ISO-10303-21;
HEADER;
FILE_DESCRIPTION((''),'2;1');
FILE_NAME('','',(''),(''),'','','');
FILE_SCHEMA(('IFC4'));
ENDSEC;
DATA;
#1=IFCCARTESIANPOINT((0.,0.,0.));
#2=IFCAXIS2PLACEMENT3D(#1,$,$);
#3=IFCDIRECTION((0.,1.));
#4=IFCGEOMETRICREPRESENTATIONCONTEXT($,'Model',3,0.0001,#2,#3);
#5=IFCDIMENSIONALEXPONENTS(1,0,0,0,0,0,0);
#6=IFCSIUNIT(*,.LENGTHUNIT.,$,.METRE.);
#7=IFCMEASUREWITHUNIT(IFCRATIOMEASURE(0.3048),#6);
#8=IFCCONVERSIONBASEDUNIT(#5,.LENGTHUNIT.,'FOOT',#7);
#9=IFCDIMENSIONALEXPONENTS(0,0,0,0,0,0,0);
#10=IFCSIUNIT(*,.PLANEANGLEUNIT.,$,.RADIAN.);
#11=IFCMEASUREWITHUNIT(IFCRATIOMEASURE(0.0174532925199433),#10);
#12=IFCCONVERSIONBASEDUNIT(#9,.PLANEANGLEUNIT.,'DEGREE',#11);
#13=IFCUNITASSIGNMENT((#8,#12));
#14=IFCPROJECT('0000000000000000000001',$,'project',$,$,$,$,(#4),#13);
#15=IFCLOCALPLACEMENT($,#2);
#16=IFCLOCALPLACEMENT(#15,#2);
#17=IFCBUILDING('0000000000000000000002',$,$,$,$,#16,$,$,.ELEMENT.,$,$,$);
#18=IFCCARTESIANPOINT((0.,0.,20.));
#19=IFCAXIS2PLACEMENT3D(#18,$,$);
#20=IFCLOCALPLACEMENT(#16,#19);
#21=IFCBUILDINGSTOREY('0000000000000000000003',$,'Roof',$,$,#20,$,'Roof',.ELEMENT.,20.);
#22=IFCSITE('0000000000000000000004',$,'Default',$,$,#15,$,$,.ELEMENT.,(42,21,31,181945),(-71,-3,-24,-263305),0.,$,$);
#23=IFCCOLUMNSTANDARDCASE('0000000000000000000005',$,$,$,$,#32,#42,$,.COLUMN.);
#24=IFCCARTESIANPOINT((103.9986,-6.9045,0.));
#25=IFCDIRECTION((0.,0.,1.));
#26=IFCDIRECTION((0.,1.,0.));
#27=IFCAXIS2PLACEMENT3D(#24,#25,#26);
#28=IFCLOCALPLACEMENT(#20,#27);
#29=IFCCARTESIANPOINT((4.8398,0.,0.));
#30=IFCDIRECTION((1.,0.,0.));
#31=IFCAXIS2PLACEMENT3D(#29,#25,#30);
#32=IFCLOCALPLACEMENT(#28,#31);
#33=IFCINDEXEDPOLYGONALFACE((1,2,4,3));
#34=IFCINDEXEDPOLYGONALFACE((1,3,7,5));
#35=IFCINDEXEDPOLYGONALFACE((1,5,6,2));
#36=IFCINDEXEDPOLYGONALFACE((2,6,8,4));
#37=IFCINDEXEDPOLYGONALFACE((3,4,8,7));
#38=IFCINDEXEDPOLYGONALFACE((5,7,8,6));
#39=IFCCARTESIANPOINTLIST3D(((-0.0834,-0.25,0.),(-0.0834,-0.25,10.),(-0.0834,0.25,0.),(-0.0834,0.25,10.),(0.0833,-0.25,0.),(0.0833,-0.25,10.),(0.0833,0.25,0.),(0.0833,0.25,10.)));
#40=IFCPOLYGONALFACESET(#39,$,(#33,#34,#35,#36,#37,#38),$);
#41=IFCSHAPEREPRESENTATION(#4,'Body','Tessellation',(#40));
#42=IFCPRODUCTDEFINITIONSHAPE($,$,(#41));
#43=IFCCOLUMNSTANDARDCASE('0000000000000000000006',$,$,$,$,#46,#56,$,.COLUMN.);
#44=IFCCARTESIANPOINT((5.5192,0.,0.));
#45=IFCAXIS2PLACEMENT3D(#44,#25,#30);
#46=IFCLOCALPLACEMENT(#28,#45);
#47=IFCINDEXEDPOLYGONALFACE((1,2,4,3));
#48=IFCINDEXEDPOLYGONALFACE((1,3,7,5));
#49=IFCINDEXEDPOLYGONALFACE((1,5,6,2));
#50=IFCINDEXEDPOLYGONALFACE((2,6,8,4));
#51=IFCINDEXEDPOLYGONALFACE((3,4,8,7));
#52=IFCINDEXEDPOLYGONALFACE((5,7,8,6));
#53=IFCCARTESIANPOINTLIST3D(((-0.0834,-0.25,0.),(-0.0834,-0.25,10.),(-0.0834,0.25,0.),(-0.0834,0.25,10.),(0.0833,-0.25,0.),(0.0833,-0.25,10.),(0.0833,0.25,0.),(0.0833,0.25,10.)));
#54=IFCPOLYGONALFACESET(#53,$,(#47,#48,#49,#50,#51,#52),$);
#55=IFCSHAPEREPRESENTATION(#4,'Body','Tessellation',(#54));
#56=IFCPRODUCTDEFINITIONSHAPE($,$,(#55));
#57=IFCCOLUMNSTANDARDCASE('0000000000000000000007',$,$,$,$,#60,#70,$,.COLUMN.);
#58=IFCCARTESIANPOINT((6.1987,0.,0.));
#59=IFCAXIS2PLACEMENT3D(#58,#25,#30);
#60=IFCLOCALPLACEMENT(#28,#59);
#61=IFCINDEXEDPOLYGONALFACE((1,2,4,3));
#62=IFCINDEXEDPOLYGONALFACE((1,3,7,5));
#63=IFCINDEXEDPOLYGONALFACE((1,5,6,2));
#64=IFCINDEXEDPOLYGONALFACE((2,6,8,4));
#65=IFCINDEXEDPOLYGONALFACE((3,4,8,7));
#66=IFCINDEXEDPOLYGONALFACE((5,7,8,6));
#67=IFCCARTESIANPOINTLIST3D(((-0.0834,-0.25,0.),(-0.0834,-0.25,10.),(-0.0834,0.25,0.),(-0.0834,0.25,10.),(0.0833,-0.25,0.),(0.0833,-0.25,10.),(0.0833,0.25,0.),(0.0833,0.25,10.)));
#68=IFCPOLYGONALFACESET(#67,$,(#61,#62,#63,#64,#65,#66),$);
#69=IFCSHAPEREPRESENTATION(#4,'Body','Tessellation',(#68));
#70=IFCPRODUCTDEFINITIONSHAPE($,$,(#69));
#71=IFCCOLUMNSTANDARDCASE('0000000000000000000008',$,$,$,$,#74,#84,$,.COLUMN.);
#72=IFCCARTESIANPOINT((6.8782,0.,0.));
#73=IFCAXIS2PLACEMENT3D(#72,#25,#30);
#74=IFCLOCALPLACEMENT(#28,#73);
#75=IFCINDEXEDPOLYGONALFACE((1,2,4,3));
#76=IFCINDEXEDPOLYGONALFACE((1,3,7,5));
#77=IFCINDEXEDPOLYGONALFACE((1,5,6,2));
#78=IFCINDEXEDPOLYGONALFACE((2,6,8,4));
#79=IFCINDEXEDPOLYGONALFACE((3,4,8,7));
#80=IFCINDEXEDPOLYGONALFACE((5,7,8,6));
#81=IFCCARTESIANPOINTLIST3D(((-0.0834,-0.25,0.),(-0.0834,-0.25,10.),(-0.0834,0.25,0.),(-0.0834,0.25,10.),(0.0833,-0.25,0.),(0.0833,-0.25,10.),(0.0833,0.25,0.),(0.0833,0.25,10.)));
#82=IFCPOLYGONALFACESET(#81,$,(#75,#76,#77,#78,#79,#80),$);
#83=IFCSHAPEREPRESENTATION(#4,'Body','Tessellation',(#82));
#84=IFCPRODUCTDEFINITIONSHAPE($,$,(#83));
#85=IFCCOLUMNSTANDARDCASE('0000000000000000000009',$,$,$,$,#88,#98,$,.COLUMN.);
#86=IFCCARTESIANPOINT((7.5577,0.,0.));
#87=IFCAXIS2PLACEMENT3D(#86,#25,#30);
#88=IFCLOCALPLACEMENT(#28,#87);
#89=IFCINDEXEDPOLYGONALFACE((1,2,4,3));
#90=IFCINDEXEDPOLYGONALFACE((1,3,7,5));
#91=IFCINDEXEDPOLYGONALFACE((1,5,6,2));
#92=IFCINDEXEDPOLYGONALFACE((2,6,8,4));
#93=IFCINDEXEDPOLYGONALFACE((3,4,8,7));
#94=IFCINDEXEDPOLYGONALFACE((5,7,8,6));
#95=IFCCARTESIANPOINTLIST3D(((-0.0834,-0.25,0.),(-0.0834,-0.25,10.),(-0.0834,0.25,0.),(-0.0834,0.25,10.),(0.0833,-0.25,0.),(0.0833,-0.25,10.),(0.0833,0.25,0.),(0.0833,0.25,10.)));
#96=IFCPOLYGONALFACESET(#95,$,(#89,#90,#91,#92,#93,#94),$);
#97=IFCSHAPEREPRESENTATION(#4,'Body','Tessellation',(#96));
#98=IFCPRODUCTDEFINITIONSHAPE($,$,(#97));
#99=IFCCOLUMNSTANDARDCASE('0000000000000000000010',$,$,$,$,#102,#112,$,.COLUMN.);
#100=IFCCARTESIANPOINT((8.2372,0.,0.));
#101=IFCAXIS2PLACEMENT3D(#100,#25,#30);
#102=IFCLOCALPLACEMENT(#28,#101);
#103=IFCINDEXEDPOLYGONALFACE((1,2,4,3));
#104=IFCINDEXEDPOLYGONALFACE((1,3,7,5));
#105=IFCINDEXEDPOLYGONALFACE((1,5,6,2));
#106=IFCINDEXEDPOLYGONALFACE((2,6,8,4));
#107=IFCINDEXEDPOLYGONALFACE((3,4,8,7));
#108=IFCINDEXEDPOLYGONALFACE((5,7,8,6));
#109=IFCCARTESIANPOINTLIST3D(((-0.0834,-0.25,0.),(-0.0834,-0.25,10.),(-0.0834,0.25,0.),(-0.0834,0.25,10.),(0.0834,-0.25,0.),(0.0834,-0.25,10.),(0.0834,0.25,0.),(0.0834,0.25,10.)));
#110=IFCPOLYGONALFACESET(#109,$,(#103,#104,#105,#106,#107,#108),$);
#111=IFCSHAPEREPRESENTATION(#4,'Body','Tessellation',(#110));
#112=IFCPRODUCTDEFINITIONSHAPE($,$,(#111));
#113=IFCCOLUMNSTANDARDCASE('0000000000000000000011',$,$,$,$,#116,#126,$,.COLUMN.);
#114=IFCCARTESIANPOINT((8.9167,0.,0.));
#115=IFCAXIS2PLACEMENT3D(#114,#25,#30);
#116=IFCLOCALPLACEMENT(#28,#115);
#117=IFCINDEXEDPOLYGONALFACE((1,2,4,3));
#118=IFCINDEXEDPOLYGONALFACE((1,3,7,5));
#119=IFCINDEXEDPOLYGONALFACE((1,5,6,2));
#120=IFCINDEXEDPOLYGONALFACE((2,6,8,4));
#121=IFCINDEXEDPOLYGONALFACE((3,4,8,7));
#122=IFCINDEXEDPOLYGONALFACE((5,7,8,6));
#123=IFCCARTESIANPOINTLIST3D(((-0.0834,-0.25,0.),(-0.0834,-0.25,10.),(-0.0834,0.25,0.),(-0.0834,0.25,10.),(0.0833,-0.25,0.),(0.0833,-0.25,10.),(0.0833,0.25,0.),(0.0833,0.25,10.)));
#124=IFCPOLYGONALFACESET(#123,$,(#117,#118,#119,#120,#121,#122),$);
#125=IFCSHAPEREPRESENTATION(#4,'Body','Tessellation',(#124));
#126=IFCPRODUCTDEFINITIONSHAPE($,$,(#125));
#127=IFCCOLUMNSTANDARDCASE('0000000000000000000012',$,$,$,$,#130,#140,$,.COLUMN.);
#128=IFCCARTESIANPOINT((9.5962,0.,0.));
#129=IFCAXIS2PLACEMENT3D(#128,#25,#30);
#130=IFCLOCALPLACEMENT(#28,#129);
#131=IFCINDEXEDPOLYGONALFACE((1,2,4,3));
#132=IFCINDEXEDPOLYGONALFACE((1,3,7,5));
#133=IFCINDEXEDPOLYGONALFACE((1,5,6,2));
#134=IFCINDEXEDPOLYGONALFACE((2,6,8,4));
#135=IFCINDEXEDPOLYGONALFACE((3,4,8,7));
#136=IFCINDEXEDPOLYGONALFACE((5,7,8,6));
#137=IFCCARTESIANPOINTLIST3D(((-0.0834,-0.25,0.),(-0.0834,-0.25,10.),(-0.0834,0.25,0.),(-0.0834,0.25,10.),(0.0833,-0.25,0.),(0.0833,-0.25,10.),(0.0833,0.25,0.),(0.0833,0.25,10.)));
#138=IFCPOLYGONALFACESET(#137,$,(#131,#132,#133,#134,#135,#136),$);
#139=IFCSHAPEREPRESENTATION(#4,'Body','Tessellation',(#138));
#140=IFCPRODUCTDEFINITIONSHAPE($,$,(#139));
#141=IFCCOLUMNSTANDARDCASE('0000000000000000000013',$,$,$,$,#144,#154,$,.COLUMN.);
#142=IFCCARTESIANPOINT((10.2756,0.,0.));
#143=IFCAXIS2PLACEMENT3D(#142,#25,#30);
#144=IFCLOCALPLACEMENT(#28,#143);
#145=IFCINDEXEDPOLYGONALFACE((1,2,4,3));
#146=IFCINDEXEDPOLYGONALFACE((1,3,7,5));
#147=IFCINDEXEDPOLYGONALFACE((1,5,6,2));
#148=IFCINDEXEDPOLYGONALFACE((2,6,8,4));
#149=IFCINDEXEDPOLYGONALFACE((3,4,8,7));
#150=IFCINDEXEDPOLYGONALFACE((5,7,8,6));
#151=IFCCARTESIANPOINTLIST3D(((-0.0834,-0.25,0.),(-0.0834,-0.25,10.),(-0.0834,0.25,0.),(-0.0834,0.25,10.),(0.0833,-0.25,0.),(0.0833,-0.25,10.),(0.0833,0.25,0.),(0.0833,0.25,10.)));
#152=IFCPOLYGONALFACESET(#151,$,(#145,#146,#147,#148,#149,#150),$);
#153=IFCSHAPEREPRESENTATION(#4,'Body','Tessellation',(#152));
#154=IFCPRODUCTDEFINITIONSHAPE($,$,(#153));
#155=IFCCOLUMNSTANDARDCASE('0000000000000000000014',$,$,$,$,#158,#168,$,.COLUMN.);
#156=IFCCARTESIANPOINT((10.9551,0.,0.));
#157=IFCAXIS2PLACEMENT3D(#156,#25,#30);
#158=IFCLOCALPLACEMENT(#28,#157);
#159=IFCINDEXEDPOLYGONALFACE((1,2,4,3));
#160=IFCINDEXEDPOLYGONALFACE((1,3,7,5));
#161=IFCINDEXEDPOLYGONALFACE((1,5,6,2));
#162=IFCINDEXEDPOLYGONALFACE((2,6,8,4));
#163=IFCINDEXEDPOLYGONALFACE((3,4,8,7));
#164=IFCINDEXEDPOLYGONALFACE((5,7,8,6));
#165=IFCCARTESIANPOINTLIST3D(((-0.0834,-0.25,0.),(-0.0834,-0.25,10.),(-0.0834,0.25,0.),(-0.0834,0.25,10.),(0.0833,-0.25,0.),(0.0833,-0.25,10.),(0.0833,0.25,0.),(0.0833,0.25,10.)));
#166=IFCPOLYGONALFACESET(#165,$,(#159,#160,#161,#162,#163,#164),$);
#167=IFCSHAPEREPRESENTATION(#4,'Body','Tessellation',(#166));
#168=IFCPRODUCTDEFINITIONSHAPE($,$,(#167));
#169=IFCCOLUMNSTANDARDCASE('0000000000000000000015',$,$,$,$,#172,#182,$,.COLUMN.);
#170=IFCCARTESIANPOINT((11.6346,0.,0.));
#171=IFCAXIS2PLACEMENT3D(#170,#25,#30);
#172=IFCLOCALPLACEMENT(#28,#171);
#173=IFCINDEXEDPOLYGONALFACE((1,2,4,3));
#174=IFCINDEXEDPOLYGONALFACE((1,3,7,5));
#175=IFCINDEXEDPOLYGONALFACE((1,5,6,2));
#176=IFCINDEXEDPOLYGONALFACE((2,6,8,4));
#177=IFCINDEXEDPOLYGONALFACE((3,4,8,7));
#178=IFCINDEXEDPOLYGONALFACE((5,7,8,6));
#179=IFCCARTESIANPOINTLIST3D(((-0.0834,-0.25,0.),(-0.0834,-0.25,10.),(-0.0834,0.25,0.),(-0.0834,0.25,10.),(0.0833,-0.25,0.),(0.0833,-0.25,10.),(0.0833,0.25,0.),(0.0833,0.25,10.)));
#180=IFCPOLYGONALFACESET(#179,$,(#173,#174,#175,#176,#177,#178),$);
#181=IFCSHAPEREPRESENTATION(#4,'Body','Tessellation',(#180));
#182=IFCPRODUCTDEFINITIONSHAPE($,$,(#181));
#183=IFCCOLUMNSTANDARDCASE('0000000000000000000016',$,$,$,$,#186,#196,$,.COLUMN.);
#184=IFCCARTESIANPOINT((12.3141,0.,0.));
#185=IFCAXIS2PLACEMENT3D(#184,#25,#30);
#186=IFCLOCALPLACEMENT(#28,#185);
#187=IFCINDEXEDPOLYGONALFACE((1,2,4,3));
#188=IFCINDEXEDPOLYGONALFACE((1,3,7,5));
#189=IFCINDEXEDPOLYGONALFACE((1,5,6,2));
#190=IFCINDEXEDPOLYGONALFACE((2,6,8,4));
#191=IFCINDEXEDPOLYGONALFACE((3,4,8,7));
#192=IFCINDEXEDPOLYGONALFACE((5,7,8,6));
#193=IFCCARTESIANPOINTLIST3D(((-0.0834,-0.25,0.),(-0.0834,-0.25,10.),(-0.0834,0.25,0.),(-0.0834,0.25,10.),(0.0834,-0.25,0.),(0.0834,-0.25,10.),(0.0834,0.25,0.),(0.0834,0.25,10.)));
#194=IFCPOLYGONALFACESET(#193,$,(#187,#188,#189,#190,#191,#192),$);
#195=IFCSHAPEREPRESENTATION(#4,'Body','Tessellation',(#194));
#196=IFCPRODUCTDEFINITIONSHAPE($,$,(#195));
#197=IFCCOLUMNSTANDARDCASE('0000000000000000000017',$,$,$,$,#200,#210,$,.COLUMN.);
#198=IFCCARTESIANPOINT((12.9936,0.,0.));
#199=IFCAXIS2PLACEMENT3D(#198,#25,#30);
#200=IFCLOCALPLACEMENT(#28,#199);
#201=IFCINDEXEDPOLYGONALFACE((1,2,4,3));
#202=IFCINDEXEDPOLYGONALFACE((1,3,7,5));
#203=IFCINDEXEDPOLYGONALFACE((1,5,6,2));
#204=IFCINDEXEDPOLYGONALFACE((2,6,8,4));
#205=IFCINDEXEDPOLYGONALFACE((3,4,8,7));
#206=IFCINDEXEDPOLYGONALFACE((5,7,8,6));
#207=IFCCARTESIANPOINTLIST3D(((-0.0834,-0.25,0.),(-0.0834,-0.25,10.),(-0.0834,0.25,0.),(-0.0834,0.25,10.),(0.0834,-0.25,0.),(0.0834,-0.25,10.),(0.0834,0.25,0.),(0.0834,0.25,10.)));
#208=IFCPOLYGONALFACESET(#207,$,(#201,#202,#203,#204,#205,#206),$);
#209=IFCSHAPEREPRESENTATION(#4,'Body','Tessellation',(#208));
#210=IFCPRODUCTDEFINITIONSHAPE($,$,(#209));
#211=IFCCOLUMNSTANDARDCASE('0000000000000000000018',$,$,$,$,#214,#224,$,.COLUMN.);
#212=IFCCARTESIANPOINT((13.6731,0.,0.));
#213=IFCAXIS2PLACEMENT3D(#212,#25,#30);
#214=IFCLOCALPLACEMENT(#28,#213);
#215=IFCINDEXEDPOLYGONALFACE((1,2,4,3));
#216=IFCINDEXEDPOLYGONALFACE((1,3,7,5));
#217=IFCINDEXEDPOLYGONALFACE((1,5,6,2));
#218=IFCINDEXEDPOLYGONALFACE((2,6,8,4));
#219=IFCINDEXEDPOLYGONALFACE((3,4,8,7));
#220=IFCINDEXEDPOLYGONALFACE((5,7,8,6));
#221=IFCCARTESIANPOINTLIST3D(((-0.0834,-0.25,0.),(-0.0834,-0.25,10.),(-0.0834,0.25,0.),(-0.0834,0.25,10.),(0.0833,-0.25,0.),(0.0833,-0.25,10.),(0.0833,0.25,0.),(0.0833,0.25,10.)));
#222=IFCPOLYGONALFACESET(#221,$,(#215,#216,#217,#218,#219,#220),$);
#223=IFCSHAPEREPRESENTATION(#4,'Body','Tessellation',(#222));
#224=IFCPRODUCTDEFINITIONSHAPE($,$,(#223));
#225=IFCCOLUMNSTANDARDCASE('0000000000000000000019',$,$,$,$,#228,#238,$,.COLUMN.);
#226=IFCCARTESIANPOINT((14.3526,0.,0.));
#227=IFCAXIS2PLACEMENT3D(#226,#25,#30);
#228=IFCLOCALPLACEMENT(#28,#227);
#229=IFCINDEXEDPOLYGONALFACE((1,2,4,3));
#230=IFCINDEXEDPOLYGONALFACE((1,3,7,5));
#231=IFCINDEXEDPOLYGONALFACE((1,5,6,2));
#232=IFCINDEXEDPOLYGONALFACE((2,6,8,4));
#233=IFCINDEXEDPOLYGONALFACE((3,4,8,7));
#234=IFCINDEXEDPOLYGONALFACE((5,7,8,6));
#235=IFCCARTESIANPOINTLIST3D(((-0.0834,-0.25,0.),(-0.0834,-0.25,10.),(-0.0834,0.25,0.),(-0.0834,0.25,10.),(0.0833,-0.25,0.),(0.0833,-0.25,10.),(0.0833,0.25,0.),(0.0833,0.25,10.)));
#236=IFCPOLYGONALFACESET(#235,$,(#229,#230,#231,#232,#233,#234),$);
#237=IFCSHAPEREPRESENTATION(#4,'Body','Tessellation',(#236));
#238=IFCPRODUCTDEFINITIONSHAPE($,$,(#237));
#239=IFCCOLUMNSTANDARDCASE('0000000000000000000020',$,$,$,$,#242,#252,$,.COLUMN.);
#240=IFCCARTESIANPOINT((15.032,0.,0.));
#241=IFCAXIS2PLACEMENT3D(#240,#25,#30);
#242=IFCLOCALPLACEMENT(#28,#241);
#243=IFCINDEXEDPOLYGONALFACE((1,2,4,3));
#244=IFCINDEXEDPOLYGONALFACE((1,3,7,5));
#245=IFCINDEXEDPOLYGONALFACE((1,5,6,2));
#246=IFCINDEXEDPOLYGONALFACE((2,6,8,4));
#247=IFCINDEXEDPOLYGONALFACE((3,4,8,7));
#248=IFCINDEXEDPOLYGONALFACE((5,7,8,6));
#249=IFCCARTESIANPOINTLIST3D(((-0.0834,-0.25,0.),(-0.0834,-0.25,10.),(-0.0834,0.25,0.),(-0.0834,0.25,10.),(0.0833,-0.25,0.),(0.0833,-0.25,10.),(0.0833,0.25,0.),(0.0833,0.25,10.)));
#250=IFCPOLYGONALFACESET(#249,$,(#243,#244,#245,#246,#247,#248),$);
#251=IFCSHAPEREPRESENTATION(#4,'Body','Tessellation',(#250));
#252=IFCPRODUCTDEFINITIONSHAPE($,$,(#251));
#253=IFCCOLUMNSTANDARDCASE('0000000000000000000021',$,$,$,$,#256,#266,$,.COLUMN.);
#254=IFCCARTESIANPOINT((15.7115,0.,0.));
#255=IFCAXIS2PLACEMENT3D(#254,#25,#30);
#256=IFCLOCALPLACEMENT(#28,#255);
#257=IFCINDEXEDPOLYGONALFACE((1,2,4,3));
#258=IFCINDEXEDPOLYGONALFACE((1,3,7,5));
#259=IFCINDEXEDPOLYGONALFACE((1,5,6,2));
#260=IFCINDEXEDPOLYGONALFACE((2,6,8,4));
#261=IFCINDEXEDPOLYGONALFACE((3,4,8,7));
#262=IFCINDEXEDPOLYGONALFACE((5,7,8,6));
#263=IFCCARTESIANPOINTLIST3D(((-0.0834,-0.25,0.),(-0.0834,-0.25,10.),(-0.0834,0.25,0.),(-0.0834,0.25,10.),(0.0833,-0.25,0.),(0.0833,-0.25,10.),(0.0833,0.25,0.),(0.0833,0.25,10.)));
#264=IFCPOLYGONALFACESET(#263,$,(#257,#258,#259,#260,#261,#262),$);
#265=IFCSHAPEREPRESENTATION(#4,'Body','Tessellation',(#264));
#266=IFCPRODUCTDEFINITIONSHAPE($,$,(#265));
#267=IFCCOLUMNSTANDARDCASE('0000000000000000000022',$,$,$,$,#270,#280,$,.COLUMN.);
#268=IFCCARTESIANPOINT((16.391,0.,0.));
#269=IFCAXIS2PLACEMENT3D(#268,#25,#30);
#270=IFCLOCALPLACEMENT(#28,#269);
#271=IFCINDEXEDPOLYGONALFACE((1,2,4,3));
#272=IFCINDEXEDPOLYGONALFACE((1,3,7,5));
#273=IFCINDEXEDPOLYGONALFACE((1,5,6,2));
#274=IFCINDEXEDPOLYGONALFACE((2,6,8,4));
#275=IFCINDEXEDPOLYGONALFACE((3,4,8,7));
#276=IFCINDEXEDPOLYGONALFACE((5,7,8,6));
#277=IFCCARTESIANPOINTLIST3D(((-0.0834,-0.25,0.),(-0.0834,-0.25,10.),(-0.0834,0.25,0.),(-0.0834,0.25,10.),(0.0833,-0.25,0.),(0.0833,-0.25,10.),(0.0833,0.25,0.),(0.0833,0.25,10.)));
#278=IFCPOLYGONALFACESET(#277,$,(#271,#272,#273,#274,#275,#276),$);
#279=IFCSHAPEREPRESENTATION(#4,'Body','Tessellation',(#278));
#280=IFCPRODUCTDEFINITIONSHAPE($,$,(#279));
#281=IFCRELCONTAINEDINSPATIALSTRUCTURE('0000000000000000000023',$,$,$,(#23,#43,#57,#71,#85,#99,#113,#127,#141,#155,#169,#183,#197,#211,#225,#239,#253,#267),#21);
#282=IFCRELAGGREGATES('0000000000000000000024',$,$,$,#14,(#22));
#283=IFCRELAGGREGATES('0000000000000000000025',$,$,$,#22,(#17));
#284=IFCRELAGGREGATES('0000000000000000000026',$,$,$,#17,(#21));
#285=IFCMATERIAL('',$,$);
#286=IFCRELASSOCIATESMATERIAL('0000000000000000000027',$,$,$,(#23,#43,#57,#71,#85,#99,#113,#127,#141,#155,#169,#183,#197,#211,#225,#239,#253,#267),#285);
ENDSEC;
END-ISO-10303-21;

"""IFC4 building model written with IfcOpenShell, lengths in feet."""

from ifc_helpers import new_model, entity, si_unit, converted_unit, direction, frame, origin, place, context, project, spatial, rectangle, extrude, material, element, save


model = new_model("IFC4")

# Units and contexts
model_context = context("Model", 3, precision=0.0001, world=origin(), true_north=direction((0.0, 1.0)))
ifc_project = project(units=[converted_unit("LENGTHUNIT", "FOOT", entity("IfcRatioMeasure", 0.3048), si_unit("LENGTHUNIT", "METRE"), dimensions=[1, 0, 0, 0, 0, 0, 0]), converted_unit("PLANEANGLEUNIT", "DEGREE", entity("IfcRatioMeasure", 0.0174532925199433), si_unit("PLANEANGLEUNIT", "RADIAN"), dimensions=[0, 0, 0, 0, 0, 0, 0])], contexts=[model_context])

# Site, building, storey
site_placement = place(None, origin())
site = spatial("IfcSite", under=ifc_project, at=site_placement, Name="Default", CompositionType="ELEMENT", RefLatitude=(42, 21, 31, 181945), RefLongitude=(-71, -3, -24, -263305), RefElevation=0.0)
building_placement = place(site_placement, origin())
building = spatial("IfcBuilding", under=site, at=building_placement, CompositionType="ELEMENT")
storey_placement = place(building_placement, frame((0.0, 0.0, 20.0)))
storey = spatial("IfcBuildingStorey", under=building, at=storey_placement, Name="Roof", LongName="Roof", CompositionType="ELEMENT", Elevation=20.0)

# Columns
ifc_material_1 = material(Name="")
placement = place(storey_placement, frame((103.9986, -6.9045, 0.0), z_axis=(0.0, 0.0, 1.0), x_axis=(0.0, 1.0, 0.0)))
for number, where, z_axis, x_axis in (
    (1, (4.8398, 0.0, 0.0), (0.0, 0.0, 1.0), (1.0, 0.0, 0.0)),
    (2, (5.5192, 0.0, 0.0), (0.0, 0.0, 1.0), (1.0, 0.0, 0.0)),
    (3, (6.1987, 0.0, 0.0), (0.0, 0.0, 1.0), (1.0, 0.0, 0.0)),
    (4, (6.8782, 0.0, 0.0), (0.0, 0.0, 1.0), (1.0, 0.0, 0.0)),
    (5, (7.5577, 0.0, 0.0), (0.0, 0.0, 1.0), (1.0, 0.0, 0.0)),
    (6, (8.2372, 0.0, 0.0), (0.0, 0.0, 1.0), (1.0, 0.0, 0.0)),
    (7, (8.9167, 0.0, 0.0), (0.0, 0.0, 1.0), (1.0, 0.0, 0.0)),
    (8, (9.5962, 0.0, 0.0), (0.0, 0.0, 1.0), (1.0, 0.0, 0.0)),
    (9, (10.2756, 0.0, 0.0), (0.0, 0.0, 1.0), (1.0, 0.0, 0.0)),
    (10, (10.9551, 0.0, 0.0), (0.0, 0.0, 1.0), (1.0, 0.0, 0.0)),
    (11, (11.6346, 0.0, 0.0), (0.0, 0.0, 1.0), (1.0, 0.0, 0.0)),
    (12, (12.3141, 0.0, 0.0), (0.0, 0.0, 1.0), (1.0, 0.0, 0.0)),
    (13, (12.9936, 0.0, 0.0), (0.0, 0.0, 1.0), (1.0, 0.0, 0.0)),
    (14, (13.6731, 0.0, 0.0), (0.0, 0.0, 1.0), (1.0, 0.0, 0.0)),
    (15, (14.3526, 0.0, 0.0), (0.0, 0.0, 1.0), (1.0, 0.0, 0.0)),
    (16, (15.032, 0.0, 0.0), (0.0, 0.0, 1.0), (1.0, 0.0, 0.0)),
    (17, (15.7115, 0.0, 0.0), (0.0, 0.0, 1.0), (1.0, 0.0, 0.0)),
    (18, (16.391, 0.0, 0.0), (0.0, 0.0, 1.0), (1.0, 0.0, 0.0)),
):
    element("IfcColumnStandardCase", number, at=place(placement, frame(where, z_axis=z_axis, x_axis=x_axis)), inside=storey, material=ifc_material_1, PredefinedType="COLUMN", context=model_context, shape_type="SweptSolid", body=[
        extrude(rectangle(XDim=0.1667, YDim=0.5), origin(), (0.0, 0.0, 1.0), 10.0),
    ])

save(model, "model.ifc")
